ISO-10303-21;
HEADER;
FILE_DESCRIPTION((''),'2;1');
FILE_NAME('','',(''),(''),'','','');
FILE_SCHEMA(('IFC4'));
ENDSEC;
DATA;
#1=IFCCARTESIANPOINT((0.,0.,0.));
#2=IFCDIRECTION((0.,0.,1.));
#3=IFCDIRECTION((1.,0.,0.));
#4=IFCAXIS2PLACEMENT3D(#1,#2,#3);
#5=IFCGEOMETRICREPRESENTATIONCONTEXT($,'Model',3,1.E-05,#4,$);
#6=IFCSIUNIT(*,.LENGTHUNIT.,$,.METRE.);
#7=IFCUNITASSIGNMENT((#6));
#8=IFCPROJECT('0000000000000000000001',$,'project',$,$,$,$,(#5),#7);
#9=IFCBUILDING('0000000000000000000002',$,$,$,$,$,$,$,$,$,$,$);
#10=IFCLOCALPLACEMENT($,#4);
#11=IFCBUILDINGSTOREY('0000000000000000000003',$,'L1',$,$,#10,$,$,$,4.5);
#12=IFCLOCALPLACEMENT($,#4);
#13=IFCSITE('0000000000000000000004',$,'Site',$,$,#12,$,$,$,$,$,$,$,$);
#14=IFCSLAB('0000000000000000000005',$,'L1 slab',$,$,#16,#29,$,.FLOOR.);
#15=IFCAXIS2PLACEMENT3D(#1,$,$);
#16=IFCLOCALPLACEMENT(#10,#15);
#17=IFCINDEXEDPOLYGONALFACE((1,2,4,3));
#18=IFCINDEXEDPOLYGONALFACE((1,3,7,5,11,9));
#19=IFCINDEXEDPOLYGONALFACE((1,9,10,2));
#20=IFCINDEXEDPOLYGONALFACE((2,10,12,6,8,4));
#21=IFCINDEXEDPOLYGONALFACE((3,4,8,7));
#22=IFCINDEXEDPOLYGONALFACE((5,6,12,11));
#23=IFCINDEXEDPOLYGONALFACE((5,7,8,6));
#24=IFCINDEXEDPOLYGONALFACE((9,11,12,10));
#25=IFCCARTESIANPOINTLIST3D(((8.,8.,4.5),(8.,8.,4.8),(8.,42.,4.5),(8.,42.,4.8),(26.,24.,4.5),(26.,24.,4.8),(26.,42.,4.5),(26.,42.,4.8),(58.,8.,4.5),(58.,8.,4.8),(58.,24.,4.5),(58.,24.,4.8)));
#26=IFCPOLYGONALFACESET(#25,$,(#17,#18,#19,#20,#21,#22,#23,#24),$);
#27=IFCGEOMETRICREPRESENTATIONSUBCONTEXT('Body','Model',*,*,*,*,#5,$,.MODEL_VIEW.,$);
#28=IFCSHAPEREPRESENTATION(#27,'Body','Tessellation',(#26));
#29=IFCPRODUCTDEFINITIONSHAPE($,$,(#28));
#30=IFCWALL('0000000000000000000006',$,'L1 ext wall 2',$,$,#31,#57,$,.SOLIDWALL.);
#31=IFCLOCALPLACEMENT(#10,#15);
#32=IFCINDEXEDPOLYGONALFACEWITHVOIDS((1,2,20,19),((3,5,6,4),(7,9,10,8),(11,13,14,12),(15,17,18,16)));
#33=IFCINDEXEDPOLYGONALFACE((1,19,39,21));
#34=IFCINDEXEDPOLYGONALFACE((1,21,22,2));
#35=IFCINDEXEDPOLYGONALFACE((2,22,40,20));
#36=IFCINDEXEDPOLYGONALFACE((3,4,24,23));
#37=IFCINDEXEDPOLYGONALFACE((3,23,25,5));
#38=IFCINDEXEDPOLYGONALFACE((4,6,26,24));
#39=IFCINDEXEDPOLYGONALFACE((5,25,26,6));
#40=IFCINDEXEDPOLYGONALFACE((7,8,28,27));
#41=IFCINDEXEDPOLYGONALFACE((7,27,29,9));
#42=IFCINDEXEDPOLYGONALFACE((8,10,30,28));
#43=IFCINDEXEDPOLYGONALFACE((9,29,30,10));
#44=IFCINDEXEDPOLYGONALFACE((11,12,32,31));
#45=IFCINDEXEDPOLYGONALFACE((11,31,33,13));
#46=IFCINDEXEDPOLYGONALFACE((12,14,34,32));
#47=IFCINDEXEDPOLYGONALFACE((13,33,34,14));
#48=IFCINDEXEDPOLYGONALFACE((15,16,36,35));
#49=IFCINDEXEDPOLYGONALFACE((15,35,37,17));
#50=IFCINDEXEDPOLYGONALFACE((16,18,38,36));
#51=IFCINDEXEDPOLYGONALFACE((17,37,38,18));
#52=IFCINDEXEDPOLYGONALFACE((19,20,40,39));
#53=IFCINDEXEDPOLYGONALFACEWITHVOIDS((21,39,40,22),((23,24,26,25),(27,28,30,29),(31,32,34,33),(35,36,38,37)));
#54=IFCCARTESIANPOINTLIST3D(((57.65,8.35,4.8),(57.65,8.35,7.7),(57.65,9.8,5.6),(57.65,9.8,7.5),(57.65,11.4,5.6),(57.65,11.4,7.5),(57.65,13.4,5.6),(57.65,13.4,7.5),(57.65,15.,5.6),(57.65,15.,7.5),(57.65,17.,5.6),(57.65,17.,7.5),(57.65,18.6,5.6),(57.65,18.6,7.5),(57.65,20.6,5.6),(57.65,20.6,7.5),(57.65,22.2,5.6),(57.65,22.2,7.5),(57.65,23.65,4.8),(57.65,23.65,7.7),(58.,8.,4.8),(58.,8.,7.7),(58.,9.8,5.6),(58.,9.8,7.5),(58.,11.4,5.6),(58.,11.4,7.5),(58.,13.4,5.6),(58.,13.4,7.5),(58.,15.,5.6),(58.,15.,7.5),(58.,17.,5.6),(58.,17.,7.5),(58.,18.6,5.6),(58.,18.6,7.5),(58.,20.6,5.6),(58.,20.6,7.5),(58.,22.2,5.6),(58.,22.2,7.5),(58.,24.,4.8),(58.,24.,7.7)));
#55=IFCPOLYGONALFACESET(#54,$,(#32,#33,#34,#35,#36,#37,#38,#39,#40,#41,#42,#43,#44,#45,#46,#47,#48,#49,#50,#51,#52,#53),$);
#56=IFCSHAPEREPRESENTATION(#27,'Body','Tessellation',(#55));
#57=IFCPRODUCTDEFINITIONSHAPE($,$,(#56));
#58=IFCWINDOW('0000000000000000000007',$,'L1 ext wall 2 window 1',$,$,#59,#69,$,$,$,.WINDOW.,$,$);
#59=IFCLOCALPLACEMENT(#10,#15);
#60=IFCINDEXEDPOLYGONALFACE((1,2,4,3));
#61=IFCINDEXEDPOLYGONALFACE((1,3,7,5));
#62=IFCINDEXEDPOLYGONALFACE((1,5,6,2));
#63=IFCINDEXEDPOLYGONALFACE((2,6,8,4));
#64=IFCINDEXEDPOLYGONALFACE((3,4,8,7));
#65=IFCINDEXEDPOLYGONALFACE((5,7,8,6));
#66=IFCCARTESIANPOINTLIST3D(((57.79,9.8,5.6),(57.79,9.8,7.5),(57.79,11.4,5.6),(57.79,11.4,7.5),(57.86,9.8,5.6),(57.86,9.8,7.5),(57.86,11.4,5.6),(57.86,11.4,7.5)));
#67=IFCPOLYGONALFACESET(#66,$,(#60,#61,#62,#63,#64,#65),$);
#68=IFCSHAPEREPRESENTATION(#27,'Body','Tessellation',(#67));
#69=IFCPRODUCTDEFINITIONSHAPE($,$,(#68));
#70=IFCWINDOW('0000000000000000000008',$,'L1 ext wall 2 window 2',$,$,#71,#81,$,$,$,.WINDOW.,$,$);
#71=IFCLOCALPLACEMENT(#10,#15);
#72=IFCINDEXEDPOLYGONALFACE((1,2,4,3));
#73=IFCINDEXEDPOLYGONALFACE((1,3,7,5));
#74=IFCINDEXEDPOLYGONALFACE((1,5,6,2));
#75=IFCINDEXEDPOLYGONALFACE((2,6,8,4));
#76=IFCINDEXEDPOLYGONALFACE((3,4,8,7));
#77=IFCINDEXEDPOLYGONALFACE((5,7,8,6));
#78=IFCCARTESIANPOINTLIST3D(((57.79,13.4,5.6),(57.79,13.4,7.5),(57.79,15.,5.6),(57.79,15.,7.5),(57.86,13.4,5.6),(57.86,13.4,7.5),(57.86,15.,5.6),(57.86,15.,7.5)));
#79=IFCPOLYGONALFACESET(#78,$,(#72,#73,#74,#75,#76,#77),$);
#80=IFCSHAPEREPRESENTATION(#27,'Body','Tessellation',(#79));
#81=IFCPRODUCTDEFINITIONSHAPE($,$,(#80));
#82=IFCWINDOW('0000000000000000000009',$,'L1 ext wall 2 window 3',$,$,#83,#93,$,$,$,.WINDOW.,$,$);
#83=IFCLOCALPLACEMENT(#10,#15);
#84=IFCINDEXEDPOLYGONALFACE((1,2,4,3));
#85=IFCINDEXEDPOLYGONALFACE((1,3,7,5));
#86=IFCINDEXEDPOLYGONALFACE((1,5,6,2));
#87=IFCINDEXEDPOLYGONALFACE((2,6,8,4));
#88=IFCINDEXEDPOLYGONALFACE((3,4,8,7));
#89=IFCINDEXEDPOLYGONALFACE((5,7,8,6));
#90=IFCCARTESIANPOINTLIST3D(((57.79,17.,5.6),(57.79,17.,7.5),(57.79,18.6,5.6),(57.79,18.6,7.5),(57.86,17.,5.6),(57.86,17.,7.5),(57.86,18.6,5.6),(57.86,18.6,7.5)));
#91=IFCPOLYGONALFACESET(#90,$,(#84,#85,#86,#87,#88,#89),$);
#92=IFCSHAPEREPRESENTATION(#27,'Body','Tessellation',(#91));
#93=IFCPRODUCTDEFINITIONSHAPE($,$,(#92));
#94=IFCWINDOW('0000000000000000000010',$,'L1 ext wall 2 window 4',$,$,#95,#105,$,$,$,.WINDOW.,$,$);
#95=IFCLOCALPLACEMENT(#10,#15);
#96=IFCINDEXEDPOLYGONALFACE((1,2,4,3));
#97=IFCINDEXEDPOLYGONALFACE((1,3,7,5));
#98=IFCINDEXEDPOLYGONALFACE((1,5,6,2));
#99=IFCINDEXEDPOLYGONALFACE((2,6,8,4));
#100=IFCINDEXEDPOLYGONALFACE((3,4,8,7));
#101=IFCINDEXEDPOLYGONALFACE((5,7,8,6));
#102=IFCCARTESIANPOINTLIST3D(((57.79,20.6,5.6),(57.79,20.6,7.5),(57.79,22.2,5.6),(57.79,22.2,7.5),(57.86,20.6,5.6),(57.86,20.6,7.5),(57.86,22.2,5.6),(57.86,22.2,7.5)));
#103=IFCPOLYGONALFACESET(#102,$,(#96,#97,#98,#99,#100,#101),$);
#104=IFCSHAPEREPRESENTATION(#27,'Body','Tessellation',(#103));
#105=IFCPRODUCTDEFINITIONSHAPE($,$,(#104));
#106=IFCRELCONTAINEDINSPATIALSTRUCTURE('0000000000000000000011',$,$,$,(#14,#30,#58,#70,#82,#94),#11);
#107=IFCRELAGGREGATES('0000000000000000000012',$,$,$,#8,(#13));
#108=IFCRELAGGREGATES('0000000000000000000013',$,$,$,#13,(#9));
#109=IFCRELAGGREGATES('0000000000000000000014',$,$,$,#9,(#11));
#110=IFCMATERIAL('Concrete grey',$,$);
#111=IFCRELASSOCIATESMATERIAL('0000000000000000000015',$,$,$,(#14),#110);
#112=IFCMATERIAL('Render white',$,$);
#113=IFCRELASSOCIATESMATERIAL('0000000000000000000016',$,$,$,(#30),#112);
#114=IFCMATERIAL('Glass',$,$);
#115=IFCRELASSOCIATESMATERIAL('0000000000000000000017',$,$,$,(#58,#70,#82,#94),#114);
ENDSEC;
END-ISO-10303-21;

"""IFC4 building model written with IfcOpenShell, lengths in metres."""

from ifc_helpers import new_model, si_unit, frame, origin_with_axes, place, context, subcontext, project, spatial, polyline, outline, extrude, material, element, fill, save


model = new_model("IFC4")

# Units and contexts
model_context = context("Model", 3, precision=1e-05, world=origin_with_axes())
body_context = subcontext(model_context, "Body", "Model", "MODEL_VIEW")
ifc_project = project(units=[si_unit("LENGTHUNIT", "METRE")], contexts=[model_context])

# Site, building, storey
site_placement = place(None, origin_with_axes())
site = spatial("IfcSite", under=ifc_project, at=site_placement, Name="Site")
building = spatial("IfcBuilding", under=site)
storey_placement = place(None, origin_with_axes())
storey = spatial("IfcBuildingStorey", under=building, at=storey_placement, Name="L1", Elevation=4.5)

# Slab
ifc_material_1 = material(Name="Concrete grey")
slab_placement = place(storey_placement, origin_with_axes())
element("IfcSlab", 1, at=slab_placement, inside=storey, material=ifc_material_1, Name="L1 slab", PredefinedType="FLOOR", context=body_context, shape_type="SweptSolid", body=[
    extrude(outline(polyline([(8.0, 8.0), (58.0, 8.0), (58.0, 24.0), (26.0, 24.0), (26.0, 42.0), (8.0, 42.0), (8.0, 8.0)])), frame((0.0, 0.0, 4.5), z_axis=(0.0, 0.0, 1.0), x_axis=(1.0, 0.0, 0.0)), (0.0, 0.0, 1.0), 0.3),
])

# Wall, openings, windows
ifc_material_2 = material(Name="Render white")
ifc_material_3 = material(Name="Glass")
wall_1_placement = place(storey_placement, origin_with_axes())
wall_1 = element("IfcWall", 2, at=wall_1_placement, inside=storey, material=ifc_material_2, Name="L1 ext wall 2", PredefinedType="SOLIDWALL", context=body_context, shape_type="SweptSolid", body=[
    extrude(outline(polyline([(58.0, 8.0), (58.0, 24.0), (57.65, 23.65), (57.65, 8.35), (58.0, 8.0)])), frame((0.0, 0.0, 4.8), z_axis=(0.0, 0.0, 1.0), x_axis=(1.0, 0.0, 0.0)), (0.0, 0.0, 1.0), 2.9),
])
opening_1_placement = place(wall_1_placement, origin_with_axes())
opening_1 = element("IfcOpeningElement", 3, at=opening_1_placement, cuts=wall_1, context=body_context, shape_type="SweptSolid", body=[
    extrude(outline(polyline([(58.05, 9.8), (58.05, 11.4), (57.6, 11.4), (57.6, 9.8), (58.05, 9.8)])), frame((0.0, 0.0, 5.6), z_axis=(0.0, 0.0, 1.0), x_axis=(1.0, 0.0, 0.0)), (0.0, 0.0, 1.0), 1.9),
])
opening_2_placement = place(wall_1_placement, origin_with_axes())
opening_2 = element("IfcOpeningElement", 4, at=opening_2_placement, cuts=wall_1, context=body_context, shape_type="SweptSolid", body=[
    extrude(outline(polyline([(58.05, 13.4), (58.05, 15.0), (57.6, 15.0), (57.6, 13.4), (58.05, 13.4)])), frame((0.0, 0.0, 5.6), z_axis=(0.0, 0.0, 1.0), x_axis=(1.0, 0.0, 0.0)), (0.0, 0.0, 1.0), 1.9),
])
opening_3_placement = place(wall_1_placement, origin_with_axes())
opening_3 = element("IfcOpeningElement", 5, at=opening_3_placement, cuts=wall_1, context=body_context, shape_type="SweptSolid", body=[
    extrude(outline(polyline([(58.05, 17.0), (58.05, 18.6), (57.6, 18.6), (57.6, 17.0), (58.05, 17.0)])), frame((0.0, 0.0, 5.6), z_axis=(0.0, 0.0, 1.0), x_axis=(1.0, 0.0, 0.0)), (0.0, 0.0, 1.0), 1.9),
])
opening_4_placement = place(wall_1_placement, origin_with_axes())
opening_4 = element("IfcOpeningElement", 6, at=opening_4_placement, cuts=wall_1, context=body_context, shape_type="SweptSolid", body=[
    extrude(outline(polyline([(58.05, 20.6), (58.05, 22.2), (57.6, 22.2), (57.6, 20.6), (58.05, 20.6)])), frame((0.0, 0.0, 5.6), z_axis=(0.0, 0.0, 1.0), x_axis=(1.0, 0.0, 0.0)), (0.0, 0.0, 1.0), 1.9),
])
window_1_placement = place(storey_placement, origin_with_axes())
window_1 = element("IfcWindow", 7, at=window_1_placement, inside=storey, material=ifc_material_3, Name="L1 ext wall 2 window 1", PredefinedType="WINDOW", context=body_context, shape_type="SweptSolid", body=[
    extrude(outline(polyline([(57.86, 9.8), (57.86, 11.4), (57.79, 11.4), (57.79, 9.8), (57.86, 9.8)])), frame((0.0, 0.0, 5.6), z_axis=(0.0, 0.0, 1.0), x_axis=(1.0, 0.0, 0.0)), (0.0, 0.0, 1.0), 1.9),
])
fill(opening_1, window_1)
window_2_placement = place(storey_placement, origin_with_axes())
window_2 = element("IfcWindow", 8, at=window_2_placement, inside=storey, material=ifc_material_3, Name="L1 ext wall 2 window 2", PredefinedType="WINDOW", context=body_context, shape_type="SweptSolid", body=[
    extrude(outline(polyline([(57.86, 13.4), (57.86, 15.0), (57.79, 15.0), (57.79, 13.4), (57.86, 13.4)])), frame((0.0, 0.0, 5.6), z_axis=(0.0, 0.0, 1.0), x_axis=(1.0, 0.0, 0.0)), (0.0, 0.0, 1.0), 1.9),
])
fill(opening_2, window_2)
window_3_placement = place(storey_placement, origin_with_axes())
window_3 = element("IfcWindow", 9, at=window_3_placement, inside=storey, material=ifc_material_3, Name="L1 ext wall 2 window 3", PredefinedType="WINDOW", context=body_context, shape_type="SweptSolid", body=[
    extrude(outline(polyline([(57.86, 17.0), (57.86, 18.6), (57.79, 18.6), (57.79, 17.0), (57.86, 17.0)])), frame((0.0, 0.0, 5.6), z_axis=(0.0, 0.0, 1.0), x_axis=(1.0, 0.0, 0.0)), (0.0, 0.0, 1.0), 1.9),
])
fill(opening_3, window_3)
window_4_placement = place(storey_placement, origin_with_axes())
window_4 = element("IfcWindow", 10, at=window_4_placement, inside=storey, material=ifc_material_3, Name="L1 ext wall 2 window 4", PredefinedType="WINDOW", context=body_context, shape_type="SweptSolid", body=[
    extrude(outline(polyline([(57.86, 20.6), (57.86, 22.2), (57.79, 22.2), (57.79, 20.6), (57.86, 20.6)])), frame((0.0, 0.0, 5.6), z_axis=(0.0, 0.0, 1.0), x_axis=(1.0, 0.0, 0.0)), (0.0, 0.0, 1.0), 1.9),
])
fill(opening_4, window_4)

save(model, "model.ifc")
